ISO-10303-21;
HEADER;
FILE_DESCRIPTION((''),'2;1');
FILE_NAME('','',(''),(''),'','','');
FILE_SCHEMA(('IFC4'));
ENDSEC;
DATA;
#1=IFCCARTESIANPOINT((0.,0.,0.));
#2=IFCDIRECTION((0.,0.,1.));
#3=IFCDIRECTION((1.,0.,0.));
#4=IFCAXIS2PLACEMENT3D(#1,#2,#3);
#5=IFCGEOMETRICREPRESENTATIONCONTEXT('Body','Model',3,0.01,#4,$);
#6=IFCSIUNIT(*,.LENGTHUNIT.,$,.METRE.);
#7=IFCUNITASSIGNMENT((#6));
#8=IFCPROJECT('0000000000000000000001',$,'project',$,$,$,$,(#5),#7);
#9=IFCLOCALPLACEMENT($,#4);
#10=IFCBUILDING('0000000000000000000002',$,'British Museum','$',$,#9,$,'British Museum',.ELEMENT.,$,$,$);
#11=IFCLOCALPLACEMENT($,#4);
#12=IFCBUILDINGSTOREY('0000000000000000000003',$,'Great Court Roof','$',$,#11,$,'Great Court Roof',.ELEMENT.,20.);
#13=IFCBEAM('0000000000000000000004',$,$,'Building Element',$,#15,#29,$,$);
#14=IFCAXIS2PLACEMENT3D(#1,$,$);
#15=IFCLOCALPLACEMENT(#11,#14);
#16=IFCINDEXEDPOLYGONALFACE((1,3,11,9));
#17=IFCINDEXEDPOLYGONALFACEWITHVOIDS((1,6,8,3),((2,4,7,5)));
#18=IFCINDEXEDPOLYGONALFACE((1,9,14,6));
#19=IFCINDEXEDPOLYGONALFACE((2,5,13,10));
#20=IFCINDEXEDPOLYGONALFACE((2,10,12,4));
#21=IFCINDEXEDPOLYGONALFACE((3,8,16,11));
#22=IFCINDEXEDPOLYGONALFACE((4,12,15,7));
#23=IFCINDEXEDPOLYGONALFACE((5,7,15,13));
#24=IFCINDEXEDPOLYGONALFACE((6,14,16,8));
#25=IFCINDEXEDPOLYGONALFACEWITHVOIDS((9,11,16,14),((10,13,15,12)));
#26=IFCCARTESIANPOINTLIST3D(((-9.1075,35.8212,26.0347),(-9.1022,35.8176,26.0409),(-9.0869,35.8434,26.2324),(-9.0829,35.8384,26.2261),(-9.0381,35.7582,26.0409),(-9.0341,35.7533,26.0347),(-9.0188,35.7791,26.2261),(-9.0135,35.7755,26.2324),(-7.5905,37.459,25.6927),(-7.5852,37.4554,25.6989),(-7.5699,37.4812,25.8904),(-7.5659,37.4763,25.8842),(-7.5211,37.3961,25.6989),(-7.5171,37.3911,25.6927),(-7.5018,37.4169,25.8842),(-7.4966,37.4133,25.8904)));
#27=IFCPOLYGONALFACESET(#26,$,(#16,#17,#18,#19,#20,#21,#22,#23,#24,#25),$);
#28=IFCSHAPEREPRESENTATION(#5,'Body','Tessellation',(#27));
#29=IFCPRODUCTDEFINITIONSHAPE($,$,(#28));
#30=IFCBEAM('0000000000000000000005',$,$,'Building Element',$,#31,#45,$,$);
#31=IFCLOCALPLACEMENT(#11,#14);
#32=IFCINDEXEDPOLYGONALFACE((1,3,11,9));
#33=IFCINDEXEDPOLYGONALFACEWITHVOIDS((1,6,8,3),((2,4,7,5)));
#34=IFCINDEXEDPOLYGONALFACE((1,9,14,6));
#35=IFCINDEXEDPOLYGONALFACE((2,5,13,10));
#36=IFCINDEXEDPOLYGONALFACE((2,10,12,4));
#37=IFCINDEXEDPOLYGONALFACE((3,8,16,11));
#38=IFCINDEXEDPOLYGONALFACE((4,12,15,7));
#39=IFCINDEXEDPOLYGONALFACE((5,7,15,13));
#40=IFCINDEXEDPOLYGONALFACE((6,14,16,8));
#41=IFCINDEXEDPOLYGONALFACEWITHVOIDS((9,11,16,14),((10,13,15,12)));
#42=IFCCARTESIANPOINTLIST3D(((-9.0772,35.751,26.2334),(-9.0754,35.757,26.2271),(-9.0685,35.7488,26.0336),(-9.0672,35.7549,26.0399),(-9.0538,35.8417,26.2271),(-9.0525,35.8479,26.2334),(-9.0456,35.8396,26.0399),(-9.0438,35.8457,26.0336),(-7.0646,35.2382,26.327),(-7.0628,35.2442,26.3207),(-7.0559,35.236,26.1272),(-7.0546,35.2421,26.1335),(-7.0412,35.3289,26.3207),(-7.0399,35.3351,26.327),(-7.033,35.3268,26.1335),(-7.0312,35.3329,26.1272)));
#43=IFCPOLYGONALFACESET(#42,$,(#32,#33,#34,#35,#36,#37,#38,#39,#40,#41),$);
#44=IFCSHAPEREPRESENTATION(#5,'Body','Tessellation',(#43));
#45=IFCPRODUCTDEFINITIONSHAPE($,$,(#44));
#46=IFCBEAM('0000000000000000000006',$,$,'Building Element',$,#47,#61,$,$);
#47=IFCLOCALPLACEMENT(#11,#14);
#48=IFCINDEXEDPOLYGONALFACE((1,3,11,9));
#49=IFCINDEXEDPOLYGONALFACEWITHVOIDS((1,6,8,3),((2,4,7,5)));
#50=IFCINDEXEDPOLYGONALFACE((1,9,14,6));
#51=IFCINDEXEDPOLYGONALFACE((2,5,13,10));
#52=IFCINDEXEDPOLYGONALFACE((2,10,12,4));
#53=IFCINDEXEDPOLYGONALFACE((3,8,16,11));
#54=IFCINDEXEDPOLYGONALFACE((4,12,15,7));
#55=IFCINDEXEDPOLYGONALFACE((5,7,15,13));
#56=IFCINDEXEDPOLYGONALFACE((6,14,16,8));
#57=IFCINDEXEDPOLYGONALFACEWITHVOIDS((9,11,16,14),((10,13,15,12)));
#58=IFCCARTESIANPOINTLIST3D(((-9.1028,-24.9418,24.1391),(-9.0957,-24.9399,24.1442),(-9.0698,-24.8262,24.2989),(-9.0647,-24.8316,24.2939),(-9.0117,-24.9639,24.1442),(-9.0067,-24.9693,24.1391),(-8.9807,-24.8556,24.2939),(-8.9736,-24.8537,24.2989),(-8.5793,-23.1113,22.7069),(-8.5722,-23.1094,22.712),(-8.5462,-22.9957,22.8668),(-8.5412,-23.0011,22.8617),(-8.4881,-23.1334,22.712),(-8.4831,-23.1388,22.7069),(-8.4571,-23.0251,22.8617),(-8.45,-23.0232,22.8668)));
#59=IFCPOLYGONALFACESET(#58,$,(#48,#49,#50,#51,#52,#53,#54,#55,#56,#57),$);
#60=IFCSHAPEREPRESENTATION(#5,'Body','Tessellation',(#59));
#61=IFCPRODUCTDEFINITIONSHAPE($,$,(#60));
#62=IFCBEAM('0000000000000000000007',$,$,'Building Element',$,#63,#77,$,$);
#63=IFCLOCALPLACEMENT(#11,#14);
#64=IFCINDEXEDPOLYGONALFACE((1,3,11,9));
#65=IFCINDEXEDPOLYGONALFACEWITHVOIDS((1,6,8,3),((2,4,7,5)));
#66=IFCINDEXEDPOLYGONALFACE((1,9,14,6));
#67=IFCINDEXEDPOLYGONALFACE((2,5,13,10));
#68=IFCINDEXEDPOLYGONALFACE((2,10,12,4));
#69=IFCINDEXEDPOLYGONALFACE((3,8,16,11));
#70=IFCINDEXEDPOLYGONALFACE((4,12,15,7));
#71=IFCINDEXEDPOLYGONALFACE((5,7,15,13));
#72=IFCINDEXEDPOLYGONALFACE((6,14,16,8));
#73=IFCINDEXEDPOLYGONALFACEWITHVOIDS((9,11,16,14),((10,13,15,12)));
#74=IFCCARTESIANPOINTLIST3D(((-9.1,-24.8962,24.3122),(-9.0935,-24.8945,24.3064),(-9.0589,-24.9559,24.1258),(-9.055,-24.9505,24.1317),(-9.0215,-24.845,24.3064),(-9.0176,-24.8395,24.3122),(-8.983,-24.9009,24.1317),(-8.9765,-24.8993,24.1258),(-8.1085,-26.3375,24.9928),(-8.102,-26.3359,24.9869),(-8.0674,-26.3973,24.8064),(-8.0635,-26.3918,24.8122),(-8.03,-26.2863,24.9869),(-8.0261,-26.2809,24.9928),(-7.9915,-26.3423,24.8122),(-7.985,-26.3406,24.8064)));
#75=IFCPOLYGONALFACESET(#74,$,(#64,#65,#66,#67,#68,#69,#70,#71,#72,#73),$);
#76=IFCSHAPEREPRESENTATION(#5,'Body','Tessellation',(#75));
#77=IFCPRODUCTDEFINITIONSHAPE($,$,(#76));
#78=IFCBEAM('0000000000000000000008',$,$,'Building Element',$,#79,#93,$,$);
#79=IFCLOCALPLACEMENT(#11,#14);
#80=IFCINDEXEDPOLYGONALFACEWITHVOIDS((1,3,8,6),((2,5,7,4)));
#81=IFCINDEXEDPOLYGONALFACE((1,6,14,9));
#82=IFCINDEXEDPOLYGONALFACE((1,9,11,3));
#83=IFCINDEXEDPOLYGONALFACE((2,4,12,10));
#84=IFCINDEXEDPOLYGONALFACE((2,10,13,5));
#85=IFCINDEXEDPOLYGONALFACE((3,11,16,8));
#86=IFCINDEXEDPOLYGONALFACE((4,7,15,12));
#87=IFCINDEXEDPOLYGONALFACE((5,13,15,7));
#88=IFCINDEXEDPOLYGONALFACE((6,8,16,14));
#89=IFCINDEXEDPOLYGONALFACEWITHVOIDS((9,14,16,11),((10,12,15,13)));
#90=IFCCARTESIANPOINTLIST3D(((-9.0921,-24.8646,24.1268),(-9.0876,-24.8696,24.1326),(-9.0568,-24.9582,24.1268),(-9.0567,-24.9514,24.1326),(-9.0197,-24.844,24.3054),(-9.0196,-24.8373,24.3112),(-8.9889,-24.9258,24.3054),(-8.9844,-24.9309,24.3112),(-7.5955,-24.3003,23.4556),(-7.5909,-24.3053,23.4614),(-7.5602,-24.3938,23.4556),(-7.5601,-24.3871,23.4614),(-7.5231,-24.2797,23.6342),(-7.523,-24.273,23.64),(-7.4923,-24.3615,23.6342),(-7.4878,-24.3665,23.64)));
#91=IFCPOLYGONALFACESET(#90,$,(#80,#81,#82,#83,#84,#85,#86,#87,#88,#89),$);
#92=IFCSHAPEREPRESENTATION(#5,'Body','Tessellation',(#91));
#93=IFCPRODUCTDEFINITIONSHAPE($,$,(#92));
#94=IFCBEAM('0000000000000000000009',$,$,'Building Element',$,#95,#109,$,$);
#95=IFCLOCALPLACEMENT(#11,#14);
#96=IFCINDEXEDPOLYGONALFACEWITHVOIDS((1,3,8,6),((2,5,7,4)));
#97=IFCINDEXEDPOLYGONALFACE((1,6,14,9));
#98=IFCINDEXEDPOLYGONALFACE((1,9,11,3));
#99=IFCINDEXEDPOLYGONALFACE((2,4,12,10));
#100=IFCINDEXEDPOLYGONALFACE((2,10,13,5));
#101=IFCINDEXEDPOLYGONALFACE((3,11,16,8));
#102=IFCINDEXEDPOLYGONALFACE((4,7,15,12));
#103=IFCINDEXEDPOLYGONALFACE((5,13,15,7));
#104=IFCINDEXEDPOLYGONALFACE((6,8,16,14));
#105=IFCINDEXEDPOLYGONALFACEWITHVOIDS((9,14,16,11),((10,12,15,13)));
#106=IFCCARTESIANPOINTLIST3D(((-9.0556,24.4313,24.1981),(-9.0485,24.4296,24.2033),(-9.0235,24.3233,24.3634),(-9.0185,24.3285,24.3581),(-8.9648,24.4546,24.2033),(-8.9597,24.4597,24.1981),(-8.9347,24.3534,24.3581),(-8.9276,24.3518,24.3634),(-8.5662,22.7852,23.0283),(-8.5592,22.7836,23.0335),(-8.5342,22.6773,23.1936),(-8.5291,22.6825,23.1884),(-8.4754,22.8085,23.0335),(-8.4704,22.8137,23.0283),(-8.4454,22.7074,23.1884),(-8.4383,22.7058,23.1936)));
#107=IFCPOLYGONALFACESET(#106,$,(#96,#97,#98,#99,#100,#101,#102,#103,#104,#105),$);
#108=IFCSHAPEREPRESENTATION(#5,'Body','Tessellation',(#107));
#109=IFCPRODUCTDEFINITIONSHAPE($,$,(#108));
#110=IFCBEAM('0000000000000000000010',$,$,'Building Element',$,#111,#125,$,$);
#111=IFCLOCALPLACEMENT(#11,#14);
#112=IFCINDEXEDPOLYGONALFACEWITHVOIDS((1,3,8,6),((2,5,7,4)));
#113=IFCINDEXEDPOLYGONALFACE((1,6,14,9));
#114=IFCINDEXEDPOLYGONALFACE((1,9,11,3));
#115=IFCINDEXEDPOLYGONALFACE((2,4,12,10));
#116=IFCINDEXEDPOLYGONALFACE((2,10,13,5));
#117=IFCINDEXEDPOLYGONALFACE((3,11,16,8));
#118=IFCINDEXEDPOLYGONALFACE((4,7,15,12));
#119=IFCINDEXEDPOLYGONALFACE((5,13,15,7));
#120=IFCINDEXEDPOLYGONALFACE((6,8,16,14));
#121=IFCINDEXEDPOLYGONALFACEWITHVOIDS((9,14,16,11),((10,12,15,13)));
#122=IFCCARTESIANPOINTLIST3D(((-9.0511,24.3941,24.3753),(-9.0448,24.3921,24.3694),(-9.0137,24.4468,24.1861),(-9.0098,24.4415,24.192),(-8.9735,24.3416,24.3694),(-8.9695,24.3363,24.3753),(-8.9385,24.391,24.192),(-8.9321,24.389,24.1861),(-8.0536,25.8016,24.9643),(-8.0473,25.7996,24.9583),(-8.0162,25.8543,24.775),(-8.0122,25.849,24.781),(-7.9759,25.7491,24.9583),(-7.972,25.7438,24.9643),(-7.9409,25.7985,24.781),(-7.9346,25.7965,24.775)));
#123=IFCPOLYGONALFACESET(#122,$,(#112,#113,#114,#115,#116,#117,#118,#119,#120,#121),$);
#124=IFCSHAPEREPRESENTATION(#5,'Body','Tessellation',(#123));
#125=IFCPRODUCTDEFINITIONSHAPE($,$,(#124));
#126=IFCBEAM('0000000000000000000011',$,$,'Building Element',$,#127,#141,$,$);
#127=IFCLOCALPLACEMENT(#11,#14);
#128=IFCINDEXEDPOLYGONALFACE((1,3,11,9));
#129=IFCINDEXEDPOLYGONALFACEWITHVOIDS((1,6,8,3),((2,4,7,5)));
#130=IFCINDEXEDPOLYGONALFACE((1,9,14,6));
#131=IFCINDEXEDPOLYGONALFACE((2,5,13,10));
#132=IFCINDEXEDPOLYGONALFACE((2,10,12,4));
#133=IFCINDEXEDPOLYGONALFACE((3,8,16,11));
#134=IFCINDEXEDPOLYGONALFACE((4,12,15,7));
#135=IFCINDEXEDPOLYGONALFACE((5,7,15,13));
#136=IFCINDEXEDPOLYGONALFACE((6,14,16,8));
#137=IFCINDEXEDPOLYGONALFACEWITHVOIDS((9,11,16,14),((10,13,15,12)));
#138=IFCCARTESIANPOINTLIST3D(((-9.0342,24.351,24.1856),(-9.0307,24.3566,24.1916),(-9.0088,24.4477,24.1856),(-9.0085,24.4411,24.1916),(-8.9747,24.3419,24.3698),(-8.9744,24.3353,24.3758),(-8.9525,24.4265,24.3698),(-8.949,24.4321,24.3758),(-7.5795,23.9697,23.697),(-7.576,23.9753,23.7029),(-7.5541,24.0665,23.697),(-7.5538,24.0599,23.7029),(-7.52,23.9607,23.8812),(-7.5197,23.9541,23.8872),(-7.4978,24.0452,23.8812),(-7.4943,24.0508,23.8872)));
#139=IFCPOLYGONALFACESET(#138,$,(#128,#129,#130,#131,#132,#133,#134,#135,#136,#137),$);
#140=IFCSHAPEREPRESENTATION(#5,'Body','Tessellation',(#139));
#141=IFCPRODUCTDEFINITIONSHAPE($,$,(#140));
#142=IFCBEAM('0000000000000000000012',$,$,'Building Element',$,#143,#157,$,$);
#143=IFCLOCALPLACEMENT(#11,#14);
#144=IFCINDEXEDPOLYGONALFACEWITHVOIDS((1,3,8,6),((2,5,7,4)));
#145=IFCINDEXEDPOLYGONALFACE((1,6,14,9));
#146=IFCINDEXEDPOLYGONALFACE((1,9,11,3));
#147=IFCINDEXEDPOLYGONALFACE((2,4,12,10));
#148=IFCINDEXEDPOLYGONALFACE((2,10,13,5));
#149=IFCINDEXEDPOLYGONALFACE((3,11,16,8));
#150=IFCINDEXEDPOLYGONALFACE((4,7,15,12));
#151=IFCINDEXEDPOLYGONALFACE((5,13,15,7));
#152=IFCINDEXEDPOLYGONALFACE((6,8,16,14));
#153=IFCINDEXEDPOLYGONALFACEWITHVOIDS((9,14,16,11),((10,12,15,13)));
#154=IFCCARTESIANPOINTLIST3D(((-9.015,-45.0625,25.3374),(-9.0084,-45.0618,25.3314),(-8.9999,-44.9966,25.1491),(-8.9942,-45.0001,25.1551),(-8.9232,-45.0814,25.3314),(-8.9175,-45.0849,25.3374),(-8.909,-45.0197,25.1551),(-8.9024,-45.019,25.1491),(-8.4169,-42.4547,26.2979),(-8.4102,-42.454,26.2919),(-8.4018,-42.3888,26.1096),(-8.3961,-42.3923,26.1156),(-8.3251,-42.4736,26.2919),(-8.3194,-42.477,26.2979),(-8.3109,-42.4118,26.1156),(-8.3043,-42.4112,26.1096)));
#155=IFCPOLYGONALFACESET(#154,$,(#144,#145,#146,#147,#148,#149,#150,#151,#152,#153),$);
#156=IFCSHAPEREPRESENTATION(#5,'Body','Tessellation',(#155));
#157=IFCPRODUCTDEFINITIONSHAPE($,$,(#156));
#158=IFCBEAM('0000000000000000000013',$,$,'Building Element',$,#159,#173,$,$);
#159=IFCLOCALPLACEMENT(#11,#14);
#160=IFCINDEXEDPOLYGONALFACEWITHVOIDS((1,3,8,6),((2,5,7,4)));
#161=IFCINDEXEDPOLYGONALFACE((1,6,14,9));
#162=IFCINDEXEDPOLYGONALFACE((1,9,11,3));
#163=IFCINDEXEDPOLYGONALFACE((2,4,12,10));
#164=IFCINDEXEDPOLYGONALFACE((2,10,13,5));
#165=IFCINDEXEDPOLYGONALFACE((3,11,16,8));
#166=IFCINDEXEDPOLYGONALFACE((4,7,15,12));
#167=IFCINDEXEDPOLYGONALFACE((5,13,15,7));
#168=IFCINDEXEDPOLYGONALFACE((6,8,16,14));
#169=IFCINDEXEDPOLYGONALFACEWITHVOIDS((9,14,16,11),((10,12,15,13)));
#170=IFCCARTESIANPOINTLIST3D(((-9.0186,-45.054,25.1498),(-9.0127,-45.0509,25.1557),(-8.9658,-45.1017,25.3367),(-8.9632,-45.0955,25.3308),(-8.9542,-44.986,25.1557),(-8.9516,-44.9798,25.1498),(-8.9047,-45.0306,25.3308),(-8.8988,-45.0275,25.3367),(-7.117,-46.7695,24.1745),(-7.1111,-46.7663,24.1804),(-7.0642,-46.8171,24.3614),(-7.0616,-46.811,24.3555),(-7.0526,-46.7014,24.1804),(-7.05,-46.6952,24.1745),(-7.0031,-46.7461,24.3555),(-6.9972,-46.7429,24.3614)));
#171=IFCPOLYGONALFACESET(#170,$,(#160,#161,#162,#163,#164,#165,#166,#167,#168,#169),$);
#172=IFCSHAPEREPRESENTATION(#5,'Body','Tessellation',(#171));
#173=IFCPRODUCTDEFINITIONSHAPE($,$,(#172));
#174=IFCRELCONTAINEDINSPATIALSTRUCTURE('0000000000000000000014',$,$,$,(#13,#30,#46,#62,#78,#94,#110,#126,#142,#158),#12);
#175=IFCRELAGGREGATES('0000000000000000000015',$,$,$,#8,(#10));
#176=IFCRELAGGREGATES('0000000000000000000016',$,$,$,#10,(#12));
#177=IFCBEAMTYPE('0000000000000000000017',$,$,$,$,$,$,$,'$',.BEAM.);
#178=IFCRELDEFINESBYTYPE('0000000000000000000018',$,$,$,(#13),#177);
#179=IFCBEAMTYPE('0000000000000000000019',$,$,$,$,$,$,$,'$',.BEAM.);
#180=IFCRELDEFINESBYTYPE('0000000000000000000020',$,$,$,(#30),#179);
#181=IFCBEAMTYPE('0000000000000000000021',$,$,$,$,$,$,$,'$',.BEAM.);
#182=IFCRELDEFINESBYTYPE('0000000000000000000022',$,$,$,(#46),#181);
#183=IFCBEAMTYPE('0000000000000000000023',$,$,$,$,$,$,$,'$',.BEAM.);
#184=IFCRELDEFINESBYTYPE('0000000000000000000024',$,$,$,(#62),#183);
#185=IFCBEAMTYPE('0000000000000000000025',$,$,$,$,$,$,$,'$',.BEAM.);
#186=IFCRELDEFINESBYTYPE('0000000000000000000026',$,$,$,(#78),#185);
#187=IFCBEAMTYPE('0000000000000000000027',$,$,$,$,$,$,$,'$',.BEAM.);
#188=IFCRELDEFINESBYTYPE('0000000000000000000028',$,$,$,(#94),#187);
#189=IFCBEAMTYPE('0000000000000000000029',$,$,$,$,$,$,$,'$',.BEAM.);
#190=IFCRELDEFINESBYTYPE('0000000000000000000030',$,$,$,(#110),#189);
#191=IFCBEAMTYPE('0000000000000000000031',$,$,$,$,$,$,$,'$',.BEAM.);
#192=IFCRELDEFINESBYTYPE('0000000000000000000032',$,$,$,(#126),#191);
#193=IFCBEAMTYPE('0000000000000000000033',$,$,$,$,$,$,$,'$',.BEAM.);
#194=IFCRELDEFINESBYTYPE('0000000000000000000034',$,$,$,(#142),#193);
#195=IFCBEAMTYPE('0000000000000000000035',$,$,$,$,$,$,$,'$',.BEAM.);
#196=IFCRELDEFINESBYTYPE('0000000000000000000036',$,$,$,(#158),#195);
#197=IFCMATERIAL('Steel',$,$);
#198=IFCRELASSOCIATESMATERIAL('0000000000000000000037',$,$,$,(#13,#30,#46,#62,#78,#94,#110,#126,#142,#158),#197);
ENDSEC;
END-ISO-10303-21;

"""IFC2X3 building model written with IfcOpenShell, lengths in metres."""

from ifc_helpers import new_model, si_unit, frame, origin_with_axes, origin_2d, place, context, project, spatial, hollow_rectangle, extrude, material, type_object, element, save


model = new_model("IFC2X3")

# Units and contexts
model_context = context("Model", 3, precision=0.01, world=origin_with_axes(), identifier="Body")
ifc_project = project(units=[si_unit("LENGTHUNIT", "METRE")], contexts=[model_context])

# Building, storey
building_placement = place(None, origin_with_axes())
building = spatial("IfcBuilding", under=ifc_project, at=building_placement, Name="British Museum", Description="$", LongName="British Museum", CompositionType="ELEMENT")
storey_placement = place(None, origin_with_axes())
storey = spatial("IfcBuildingStorey", under=building, at=storey_placement, Name="Great Court Roof", Description="$", LongName="Great Court Roof", CompositionType="ELEMENT", Elevation=20.0)

# Beams
ifc_material = material(Name="Steel")
beam_type_1 = type_object("IfcBeamType", ElementType="$", PredefinedType="BEAM")
beam_1_placement = place(None, origin_with_axes())
element("IfcBeam", 1, at=beam_1_placement, inside=storey, type_object=beam_type_1, material=ifc_material, Description="Building Element", context=model_context, shape_type="SweptSolid", body=[
    extrude(hollow_rectangle(XDim=0.1, YDim=0.2, WallThickness=0.0063, InnerFilletRadius=-0.0063, OuterFilletRadius=0.0, at=origin_2d()), frame((-9.0605, 35.7983, 26.1335), z_axis=(0.671688, 0.725194, -0.151426), x_axis=(-0.733654, 0.679523, 0.0)), (0.0, 0.0, 1.0), 2.2585),
])
beam_type_2 = type_object("IfcBeamType", ElementType="$", PredefinedType="BEAM")
beam_2_placement = place(None, origin_with_axes())
element("IfcBeam", 2, at=beam_2_placement, inside=storey, type_object=beam_type_2, material=ifc_material, Description="Building Element", context=model_context, shape_type="SweptSolid", body=[
    extrude(hollow_rectangle(XDim=0.1, YDim=0.2, WallThickness=0.0063, InnerFilletRadius=-0.0063, OuterFilletRadius=0.0, at=origin_2d()), frame((-9.0605, 35.7983, 26.1335), z_axis=(0.968057, -0.246658, 0.045016), x_axis=(0.246908, 0.969039, 0.0)), (0.0, 0.0, 1.0), 2.079),
])
beam_type_3 = type_object("IfcBeamType", ElementType="$", PredefinedType="BEAM")
beam_3_placement = place(None, origin_with_axes())
element("IfcBeam", 3, at=beam_3_placement, inside=storey, type_object=beam_type_3, material=ifc_material, Description="Building Element", context=model_context, shape_type="SweptSolid", body=[
    extrude(hollow_rectangle(XDim=0.1, YDim=0.2, WallThickness=0.0063, InnerFilletRadius=-0.0063, OuterFilletRadius=0.0, at=origin_2d()), frame((-9.0382, -24.8977, 24.219), z_axis=(0.219762, 0.768322, -0.601154), x_axis=(-0.961444, 0.275, 0.0)), (0.0, 0.0, 1.0), 2.3824),
])
beam_type_4 = type_object("IfcBeamType", ElementType="$", PredefinedType="BEAM")
beam_4_placement = place(None, origin_with_axes())
element("IfcBeam", 4, at=beam_4_placement, inside=storey, type_object=beam_type_4, material=ifc_material, Description="Building Element", context=model_context, shape_type="SweptSolid", body=[
    extrude(hollow_rectangle(XDim=0.1, YDim=0.2, WallThickness=0.0063, InnerFilletRadius=-0.0063, OuterFilletRadius=0.0, at=origin_2d()), frame((-9.0382, -24.8977, 24.219), z_axis=(0.52819, -0.767845, 0.362532), x_axis=(0.823894, 0.566744, 0.0)), (0.0, 0.0, 1.0), 1.8771),
])
beam_type_5 = type_object("IfcBeamType", ElementType="$", PredefinedType="BEAM")
beam_5_placement = place(None, origin_with_axes())
element("IfcBeam", 5, at=beam_5_placement, inside=storey, type_object=beam_type_5, material=ifc_material, Description="Building Element", context=model_context, shape_type="SweptSolid", body=[
    extrude(hollow_rectangle(XDim=0.1, YDim=0.2, WallThickness=0.0063, InnerFilletRadius=-0.0063, OuterFilletRadius=0.0, at=origin_2d()), frame((-9.0382, -24.8977, 24.219), z_axis=(0.862802, 0.325332, -0.386953), x_axis=(-0.352817, 0.935693, 0.0)), (0.0, 0.0, 1.0), 1.7346),
])
beam_type_6 = type_object("IfcBeamType", ElementType="$", PredefinedType="BEAM")
beam_6_placement = place(None, origin_with_axes())
element("IfcBeam", 6, at=beam_6_placement, inside=storey, type_object=beam_type_6, material=ifc_material, Description="Building Element", context=model_context, shape_type="SweptSolid", body=[
    extrude(hollow_rectangle(XDim=0.1, YDim=0.2, WallThickness=0.0063, InnerFilletRadius=-0.0063, OuterFilletRadius=0.0, at=origin_2d()), frame((-8.9916, 24.3915, 24.2807), z_axis=(0.235508, -0.79221, -0.562974), x_axis=(0.958541, 0.284955, 0.0)), (0.0, 0.0, 1.0), 2.0778),
])
beam_type_7 = type_object("IfcBeamType", ElementType="$", PredefinedType="BEAM")
beam_7_placement = place(None, origin_with_axes())
element("IfcBeam", 7, at=beam_7_placement, inside=storey, type_object=beam_type_7, material=ifc_material, Description="Building Element", context=model_context, shape_type="SweptSolid", body=[
    extrude(hollow_rectangle(XDim=0.1, YDim=0.2, WallThickness=0.0063, InnerFilletRadius=-0.0063, OuterFilletRadius=0.0, at=origin_2d()), frame((-8.9916, 24.3915, 24.2807), z_axis=(0.547206, 0.772133, 0.323073), x_axis=(-0.815885, 0.578214, 0.0)), (0.0, 0.0, 1.0), 1.8229),
])
beam_type_8 = type_object("IfcBeamType", ElementType="$", PredefinedType="BEAM")
beam_8_placement = place(None, origin_with_axes())
element("IfcBeam", 8, at=beam_8_placement, inside=storey, type_object=beam_type_8, material=ifc_material, Description="Building Element", context=model_context, shape_type="SweptSolid", body=[
    extrude(hollow_rectangle(XDim=0.1, YDim=0.2, WallThickness=0.0063, InnerFilletRadius=-0.0063, OuterFilletRadius=0.0, at=origin_2d()), frame((-8.9916, 24.3915, 24.2807), z_axis=(0.919982, -0.241116, -0.309025), x_axis=(0.253525, 0.967329, 0.0)), (0.0, 0.0, 1.0), 1.5812),
])
beam_type_9 = type_object("IfcBeamType", ElementType="$", PredefinedType="BEAM")
beam_9_placement = place(None, origin_with_axes())
element("IfcBeam", 9, at=beam_9_placement, inside=storey, type_object=beam_type_9, material=ifc_material, Description="Building Element", context=model_context, shape_type="SweptSolid", body=[
    extrude(hollow_rectangle(XDim=0.1, YDim=0.2, WallThickness=0.0063, InnerFilletRadius=-0.0063, OuterFilletRadius=0.0, at=origin_2d()), frame((-8.9587, -45.0408, 25.2432), z_axis=(0.210403, 0.917368, 0.337885), x_axis=(-0.974692, 0.223551, 0.0)), (0.0, 0.0, 1.0), 2.8427),
])
beam_type_10 = type_object("IfcBeamType", ElementType="$", PredefinedType="BEAM")
beam_10_placement = place(None, origin_with_axes())
element("IfcBeam", 10, at=beam_10_placement, inside=storey, type_object=beam_type_10, material=ifc_material, Description="Building Element", context=model_context, shape_type="SweptSolid", body=[
    extrude(hollow_rectangle(XDim=0.1, YDim=0.2, WallThickness=0.0063, InnerFilletRadius=-0.0063, OuterFilletRadius=0.0, at=origin_2d()), frame((-8.9587, -45.0408, 25.2432), z_axis=(0.6939, -0.62597, -0.3559), x_axis=(0.669827, 0.742517, 0.0)), (0.0, 0.0, 1.0), 2.7404),
])

save(model, "model.ifc")
